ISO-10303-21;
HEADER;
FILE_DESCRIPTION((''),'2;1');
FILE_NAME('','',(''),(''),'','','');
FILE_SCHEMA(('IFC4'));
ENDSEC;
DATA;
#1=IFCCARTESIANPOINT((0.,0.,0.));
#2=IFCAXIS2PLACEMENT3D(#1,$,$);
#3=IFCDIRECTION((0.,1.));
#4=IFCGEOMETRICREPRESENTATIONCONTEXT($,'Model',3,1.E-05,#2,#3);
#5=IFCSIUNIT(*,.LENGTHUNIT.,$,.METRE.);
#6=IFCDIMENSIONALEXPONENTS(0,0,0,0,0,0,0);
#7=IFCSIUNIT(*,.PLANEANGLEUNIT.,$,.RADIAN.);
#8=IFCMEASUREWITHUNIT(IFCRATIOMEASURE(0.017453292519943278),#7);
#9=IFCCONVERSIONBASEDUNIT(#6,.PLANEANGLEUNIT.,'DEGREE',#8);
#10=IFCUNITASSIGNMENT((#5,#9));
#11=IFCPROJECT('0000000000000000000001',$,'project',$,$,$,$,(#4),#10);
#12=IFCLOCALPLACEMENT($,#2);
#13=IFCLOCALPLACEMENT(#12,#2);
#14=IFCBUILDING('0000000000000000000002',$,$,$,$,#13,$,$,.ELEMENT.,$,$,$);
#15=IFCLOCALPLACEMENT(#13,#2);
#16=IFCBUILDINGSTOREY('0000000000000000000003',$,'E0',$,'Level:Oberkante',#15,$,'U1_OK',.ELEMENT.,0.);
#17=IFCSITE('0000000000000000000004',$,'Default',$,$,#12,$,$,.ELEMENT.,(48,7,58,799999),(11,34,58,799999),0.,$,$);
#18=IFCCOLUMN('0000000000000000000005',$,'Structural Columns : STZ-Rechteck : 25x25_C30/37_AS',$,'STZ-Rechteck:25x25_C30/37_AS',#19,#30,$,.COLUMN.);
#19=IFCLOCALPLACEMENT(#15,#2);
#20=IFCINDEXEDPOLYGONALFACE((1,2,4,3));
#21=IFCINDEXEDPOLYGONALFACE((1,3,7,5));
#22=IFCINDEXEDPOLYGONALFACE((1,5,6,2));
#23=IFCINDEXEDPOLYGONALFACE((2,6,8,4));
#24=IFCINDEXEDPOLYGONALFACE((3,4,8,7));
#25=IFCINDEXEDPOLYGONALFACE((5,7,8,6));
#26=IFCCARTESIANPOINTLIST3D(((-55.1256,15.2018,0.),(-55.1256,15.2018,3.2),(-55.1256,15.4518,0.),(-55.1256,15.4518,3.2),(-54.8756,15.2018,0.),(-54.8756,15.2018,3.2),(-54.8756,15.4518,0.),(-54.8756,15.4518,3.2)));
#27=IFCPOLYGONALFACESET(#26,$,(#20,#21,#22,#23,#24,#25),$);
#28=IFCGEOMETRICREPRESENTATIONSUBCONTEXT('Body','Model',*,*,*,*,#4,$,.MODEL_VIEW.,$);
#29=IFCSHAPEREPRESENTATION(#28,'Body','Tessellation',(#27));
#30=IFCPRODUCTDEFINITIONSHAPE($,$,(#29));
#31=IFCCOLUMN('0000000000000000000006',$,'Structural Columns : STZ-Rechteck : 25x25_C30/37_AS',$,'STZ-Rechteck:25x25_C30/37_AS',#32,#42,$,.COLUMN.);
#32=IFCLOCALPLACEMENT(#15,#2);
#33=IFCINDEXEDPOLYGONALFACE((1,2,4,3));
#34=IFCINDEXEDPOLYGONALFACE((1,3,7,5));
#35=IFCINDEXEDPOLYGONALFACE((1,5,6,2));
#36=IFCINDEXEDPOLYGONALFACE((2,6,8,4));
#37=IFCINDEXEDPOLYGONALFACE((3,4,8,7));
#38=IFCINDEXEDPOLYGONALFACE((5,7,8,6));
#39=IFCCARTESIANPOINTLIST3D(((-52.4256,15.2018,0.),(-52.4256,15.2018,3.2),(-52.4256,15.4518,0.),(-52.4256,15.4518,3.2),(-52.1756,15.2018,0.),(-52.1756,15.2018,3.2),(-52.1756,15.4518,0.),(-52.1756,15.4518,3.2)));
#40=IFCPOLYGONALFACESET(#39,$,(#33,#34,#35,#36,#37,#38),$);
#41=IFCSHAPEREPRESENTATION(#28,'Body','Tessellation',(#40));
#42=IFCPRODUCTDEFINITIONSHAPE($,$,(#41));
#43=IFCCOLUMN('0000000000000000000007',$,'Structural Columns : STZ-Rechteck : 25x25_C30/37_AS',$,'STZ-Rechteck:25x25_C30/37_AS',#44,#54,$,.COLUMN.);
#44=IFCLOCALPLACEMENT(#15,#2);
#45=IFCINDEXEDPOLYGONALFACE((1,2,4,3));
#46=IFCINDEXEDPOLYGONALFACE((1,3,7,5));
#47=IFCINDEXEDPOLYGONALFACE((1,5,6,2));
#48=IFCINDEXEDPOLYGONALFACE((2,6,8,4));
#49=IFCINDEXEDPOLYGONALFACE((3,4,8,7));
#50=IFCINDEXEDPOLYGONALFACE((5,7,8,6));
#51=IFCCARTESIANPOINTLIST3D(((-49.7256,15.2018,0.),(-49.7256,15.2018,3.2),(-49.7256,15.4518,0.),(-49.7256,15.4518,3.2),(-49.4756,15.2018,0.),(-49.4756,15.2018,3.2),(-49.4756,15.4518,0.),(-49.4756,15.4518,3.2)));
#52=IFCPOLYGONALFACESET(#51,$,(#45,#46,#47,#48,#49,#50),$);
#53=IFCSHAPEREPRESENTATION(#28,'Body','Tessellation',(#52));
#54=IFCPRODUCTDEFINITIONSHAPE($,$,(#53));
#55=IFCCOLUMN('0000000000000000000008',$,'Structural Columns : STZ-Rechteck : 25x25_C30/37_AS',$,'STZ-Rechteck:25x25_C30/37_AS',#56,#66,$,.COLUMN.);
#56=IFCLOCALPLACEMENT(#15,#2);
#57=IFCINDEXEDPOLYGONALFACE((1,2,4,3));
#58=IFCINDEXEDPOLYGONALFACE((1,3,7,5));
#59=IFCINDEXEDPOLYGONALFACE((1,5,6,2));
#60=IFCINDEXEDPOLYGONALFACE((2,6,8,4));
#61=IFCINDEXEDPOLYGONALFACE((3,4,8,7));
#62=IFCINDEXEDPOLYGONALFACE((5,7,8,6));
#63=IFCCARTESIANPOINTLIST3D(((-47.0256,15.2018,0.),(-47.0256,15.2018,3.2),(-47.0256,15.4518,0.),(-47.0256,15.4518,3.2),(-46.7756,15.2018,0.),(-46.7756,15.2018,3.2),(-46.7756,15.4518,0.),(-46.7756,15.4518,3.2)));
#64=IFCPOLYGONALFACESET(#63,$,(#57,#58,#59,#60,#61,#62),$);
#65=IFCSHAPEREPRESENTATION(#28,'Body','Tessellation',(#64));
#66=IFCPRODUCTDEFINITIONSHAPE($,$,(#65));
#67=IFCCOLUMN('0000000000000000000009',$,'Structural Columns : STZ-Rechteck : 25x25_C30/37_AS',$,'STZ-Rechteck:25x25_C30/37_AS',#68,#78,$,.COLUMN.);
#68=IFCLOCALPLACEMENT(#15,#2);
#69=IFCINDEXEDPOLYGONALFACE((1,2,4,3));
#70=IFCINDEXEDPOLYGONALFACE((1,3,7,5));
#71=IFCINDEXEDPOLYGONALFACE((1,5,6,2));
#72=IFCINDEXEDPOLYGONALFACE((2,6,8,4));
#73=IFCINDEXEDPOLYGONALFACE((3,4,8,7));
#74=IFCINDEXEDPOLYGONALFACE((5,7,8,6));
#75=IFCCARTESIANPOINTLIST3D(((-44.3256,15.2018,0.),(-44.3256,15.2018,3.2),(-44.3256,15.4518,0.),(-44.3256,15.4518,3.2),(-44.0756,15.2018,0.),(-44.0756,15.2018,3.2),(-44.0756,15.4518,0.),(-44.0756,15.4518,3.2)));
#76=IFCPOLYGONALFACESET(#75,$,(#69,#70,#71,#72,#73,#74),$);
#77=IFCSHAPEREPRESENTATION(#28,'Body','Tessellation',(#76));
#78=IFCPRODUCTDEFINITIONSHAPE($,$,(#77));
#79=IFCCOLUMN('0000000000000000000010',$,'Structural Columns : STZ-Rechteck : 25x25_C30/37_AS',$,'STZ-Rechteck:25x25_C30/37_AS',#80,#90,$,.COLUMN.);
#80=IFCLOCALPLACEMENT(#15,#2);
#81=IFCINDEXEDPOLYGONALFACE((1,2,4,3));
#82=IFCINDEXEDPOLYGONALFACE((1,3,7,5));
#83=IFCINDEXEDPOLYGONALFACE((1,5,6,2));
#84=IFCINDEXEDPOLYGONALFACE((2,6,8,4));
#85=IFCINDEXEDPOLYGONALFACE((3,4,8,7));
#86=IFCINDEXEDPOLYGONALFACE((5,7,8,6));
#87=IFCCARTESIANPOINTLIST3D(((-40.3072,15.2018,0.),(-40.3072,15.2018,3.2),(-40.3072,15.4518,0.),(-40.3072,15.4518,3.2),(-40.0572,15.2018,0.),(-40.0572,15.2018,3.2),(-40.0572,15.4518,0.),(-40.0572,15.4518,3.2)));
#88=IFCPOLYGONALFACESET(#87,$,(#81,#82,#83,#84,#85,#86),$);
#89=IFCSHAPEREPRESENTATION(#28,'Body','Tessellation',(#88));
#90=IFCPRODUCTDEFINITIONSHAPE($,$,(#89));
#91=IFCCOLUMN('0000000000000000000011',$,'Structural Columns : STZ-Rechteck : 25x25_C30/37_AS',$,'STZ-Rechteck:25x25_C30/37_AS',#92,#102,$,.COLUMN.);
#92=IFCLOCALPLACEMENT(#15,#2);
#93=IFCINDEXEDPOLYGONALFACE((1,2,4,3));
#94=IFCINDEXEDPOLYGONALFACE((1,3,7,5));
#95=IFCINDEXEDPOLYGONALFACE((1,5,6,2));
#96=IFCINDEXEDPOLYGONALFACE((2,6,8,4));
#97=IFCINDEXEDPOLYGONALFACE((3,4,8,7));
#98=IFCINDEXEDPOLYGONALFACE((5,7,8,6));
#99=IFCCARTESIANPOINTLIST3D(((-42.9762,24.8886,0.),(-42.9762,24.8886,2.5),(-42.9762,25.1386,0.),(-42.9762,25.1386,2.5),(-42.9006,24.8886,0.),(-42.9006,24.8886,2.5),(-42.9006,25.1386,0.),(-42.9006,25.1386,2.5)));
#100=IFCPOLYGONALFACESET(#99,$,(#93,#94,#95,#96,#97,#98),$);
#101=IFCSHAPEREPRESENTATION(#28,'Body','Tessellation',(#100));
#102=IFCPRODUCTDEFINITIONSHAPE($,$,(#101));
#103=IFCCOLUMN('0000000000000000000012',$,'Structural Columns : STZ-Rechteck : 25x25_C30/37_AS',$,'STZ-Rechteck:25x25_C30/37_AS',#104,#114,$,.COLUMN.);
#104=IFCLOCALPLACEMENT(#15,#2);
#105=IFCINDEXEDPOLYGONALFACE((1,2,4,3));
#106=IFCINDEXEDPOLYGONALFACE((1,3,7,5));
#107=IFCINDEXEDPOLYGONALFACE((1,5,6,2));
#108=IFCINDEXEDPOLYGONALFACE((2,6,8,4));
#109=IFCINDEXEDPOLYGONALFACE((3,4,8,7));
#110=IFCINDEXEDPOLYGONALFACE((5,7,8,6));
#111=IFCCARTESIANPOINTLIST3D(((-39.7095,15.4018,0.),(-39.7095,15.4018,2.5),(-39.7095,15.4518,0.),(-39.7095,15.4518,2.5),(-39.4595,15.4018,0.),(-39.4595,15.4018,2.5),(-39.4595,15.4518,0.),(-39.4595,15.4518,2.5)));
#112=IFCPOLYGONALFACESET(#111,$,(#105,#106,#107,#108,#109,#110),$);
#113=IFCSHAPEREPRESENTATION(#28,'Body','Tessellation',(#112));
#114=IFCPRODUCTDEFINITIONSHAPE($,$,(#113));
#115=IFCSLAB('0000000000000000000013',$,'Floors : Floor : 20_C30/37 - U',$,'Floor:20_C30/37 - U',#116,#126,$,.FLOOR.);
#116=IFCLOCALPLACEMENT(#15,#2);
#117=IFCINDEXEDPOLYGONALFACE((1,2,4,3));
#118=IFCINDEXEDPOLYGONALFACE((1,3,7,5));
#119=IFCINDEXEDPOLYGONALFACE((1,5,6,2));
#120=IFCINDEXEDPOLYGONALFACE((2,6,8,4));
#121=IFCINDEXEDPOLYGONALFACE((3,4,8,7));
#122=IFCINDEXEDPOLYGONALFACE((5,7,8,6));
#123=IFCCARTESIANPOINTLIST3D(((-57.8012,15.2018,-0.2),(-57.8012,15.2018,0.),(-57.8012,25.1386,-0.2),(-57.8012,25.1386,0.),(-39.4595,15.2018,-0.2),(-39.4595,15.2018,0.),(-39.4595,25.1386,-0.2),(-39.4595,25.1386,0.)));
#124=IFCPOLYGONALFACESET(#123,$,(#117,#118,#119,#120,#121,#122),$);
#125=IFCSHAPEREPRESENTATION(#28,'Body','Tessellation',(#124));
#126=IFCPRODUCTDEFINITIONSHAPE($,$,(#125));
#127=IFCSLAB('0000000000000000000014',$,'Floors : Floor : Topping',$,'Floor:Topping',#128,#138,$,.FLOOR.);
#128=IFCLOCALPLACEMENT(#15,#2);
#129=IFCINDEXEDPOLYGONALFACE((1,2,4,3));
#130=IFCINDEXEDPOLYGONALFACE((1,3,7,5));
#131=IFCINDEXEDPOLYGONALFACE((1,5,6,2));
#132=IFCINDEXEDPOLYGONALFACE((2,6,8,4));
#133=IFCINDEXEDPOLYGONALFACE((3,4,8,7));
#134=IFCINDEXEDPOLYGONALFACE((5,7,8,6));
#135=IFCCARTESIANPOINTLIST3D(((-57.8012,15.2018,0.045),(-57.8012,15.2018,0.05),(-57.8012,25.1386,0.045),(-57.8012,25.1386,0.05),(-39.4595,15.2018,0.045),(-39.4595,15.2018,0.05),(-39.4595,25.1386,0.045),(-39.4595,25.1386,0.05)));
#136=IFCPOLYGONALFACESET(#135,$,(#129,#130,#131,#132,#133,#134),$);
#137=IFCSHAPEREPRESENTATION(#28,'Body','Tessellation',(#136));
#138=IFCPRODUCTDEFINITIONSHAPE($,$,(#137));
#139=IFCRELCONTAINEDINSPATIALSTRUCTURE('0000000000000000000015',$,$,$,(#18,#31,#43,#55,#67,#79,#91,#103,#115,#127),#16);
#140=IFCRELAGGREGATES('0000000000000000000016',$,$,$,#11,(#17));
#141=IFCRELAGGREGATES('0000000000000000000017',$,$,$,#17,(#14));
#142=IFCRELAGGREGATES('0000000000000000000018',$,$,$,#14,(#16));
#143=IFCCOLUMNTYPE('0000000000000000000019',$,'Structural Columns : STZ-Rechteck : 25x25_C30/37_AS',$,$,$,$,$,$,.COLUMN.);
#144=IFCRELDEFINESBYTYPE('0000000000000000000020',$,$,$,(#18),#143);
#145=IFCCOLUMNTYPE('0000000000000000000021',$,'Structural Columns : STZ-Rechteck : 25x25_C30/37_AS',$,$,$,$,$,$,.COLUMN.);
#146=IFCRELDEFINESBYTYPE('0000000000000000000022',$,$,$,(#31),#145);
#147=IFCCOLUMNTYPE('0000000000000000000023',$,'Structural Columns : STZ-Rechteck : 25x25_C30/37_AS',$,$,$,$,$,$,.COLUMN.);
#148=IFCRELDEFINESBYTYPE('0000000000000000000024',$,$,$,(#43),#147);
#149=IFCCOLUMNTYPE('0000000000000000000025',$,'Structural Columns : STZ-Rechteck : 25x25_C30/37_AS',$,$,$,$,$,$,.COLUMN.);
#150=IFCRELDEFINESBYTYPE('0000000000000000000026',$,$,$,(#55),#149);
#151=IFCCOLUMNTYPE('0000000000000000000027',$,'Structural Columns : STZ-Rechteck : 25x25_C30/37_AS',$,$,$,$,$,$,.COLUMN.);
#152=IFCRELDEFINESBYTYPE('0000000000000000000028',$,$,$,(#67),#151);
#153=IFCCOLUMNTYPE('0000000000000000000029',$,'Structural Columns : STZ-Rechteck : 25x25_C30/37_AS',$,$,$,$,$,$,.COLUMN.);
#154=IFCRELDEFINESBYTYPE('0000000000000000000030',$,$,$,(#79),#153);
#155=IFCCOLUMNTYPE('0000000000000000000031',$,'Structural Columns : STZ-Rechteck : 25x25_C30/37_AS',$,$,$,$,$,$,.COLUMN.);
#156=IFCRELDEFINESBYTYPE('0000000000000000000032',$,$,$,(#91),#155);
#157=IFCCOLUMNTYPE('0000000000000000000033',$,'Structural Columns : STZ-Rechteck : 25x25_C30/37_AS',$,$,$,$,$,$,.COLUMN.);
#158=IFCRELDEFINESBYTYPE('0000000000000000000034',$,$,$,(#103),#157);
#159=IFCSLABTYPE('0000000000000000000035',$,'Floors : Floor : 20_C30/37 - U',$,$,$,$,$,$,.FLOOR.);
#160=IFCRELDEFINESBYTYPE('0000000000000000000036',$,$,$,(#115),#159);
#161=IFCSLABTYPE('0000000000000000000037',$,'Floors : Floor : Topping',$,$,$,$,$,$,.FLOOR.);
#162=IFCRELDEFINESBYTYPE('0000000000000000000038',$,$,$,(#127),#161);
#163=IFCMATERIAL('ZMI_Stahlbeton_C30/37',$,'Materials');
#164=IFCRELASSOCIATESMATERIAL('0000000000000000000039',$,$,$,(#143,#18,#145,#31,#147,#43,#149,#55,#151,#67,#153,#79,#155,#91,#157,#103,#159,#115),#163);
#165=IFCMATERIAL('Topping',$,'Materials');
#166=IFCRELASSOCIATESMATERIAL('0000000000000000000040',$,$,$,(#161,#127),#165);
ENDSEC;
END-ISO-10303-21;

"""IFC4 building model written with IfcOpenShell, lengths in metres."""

from ifc_helpers import new_model, entity, si_unit, converted_unit, direction, frame, origin, place, context, subcontext, project, spatial, indexed_curve, outline, extrude, source, transform, mapped, material, type_object, type_shapes, element, save


model = new_model("IFC4")

# Units and contexts
model_context = context("Model", 3, precision=1e-05, world=origin(), true_north=direction((0.0, 1.0)))
body_context = subcontext(model_context, "Body", "Model", "MODEL_VIEW")
ifc_project = project(units=[si_unit("LENGTHUNIT", "METRE"), converted_unit("PLANEANGLEUNIT", "DEGREE", entity("IfcRatioMeasure", 0.017453292519943278), si_unit("PLANEANGLEUNIT", "RADIAN"), dimensions=[0, 0, 0, 0, 0, 0, 0])], contexts=[model_context])

# Site, building, storey
site_placement = place(None, origin())
site = spatial("IfcSite", under=ifc_project, at=site_placement, Name="Default", CompositionType="ELEMENT", RefLatitude=(48, 7, 58, 799999), RefLongitude=(11, 34, 58, 799999), RefElevation=0.0)
building_placement = place(site_placement, origin())
building = spatial("IfcBuilding", under=site, at=building_placement, CompositionType="ELEMENT")
storey_placement = place(building_placement, origin())
storey = spatial("IfcBuildingStorey", under=building, at=storey_placement, Name="E0", ObjectType="Level:Oberkante", LongName="U1_OK", CompositionType="ELEMENT", Elevation=0.0)

# Columns
ifc_material_1 = material(Name="ZMI_Stahlbeton_C30/37", Category="Materials")
column_type_1 = type_object("IfcColumnType", Name="Structural Columns : STZ-Rechteck : 25x25_C30/37_AS", PredefinedType="COLUMN", material=ifc_material_1)
shared_shape_1 = source(origin(), body_context, "Body", "SweptSolid", [
    extrude(outline(indexed_curve([(-0.125, -0.125), (0.125, -0.125), (0.125, 0.125), (-0.125, 0.125), (-0.125, -0.125)], self_intersect=False)), frame((-55.0006, 15.3268, 0.0), z_axis=(0.0, 0.0, 1.0), x_axis=(0.0, -1.0, 0.0)), (0.0, 0.0, 1.0), 3.2),
])
type_shapes(column_type_1, [shared_shape_1])
column_1_placement = place(storey_placement, origin())
element("IfcColumn", 1, at=column_1_placement, inside=storey, type_object=column_type_1, material=ifc_material_1, Name="Structural Columns : STZ-Rechteck : 25x25_C30/37_AS", ObjectType="STZ-Rechteck:25x25_C30/37_AS", PredefinedType="COLUMN", context=body_context, shape_type="MappedRepresentation", body=[
    mapped(shared_shape_1, transform((0.0, 0.0, 0.0), scale=1.0)),
])
column_type_2 = type_object("IfcColumnType", Name="Structural Columns : STZ-Rechteck : 25x25_C30/37_AS", PredefinedType="COLUMN", material=ifc_material_1)
shared_shape_2 = source(origin(), body_context, "Body", "SweptSolid", [
    extrude(outline(indexed_curve([(-0.125, -0.125), (0.125, -0.125), (0.125, 0.125), (-0.125, 0.125), (-0.125, -0.125)], self_intersect=False)), frame((-52.3006, 15.3268, 0.0), z_axis=(0.0, 0.0, 1.0), x_axis=(0.0, -1.0, 0.0)), (0.0, 0.0, 1.0), 3.2),
])
type_shapes(column_type_2, [shared_shape_2])
column_2_placement = place(storey_placement, origin())
element("IfcColumn", 2, at=column_2_placement, inside=storey, type_object=column_type_2, material=ifc_material_1, Name="Structural Columns : STZ-Rechteck : 25x25_C30/37_AS", ObjectType="STZ-Rechteck:25x25_C30/37_AS", PredefinedType="COLUMN", context=body_context, shape_type="MappedRepresentation", body=[
    mapped(shared_shape_2, transform((0.0, 0.0, 0.0), scale=1.0)),
])
column_type_3 = type_object("IfcColumnType", Name="Structural Columns : STZ-Rechteck : 25x25_C30/37_AS", PredefinedType="COLUMN", material=ifc_material_1)
shared_shape_3 = source(origin(), body_context, "Body", "SweptSolid", [
    extrude(outline(indexed_curve([(-0.125, -0.125), (0.125, -0.125), (0.125, 0.125), (-0.125, 0.125), (-0.125, -0.125)], self_intersect=False)), frame((-49.6006, 15.3268, 0.0), z_axis=(0.0, 0.0, 1.0), x_axis=(0.0, -1.0, 0.0)), (0.0, 0.0, 1.0), 3.2),
])
type_shapes(column_type_3, [shared_shape_3])
column_3_placement = place(storey_placement, origin())
element("IfcColumn", 3, at=column_3_placement, inside=storey, type_object=column_type_3, material=ifc_material_1, Name="Structural Columns : STZ-Rechteck : 25x25_C30/37_AS", ObjectType="STZ-Rechteck:25x25_C30/37_AS", PredefinedType="COLUMN", context=body_context, shape_type="MappedRepresentation", body=[
    mapped(shared_shape_3, transform((0.0, 0.0, 0.0), scale=1.0)),
])
column_type_4 = type_object("IfcColumnType", Name="Structural Columns : STZ-Rechteck : 25x25_C30/37_AS", PredefinedType="COLUMN", material=ifc_material_1)
shared_shape_4 = source(origin(), body_context, "Body", "SweptSolid", [
    extrude(outline(indexed_curve([(-0.125, -0.125), (0.125, -0.125), (0.125, 0.125), (-0.125, 0.125), (-0.125, -0.125)], self_intersect=False)), frame((-46.9006, 15.3268, 0.0), z_axis=(0.0, 0.0, 1.0), x_axis=(0.0, -1.0, 0.0)), (0.0, 0.0, 1.0), 3.2),
])
type_shapes(column_type_4, [shared_shape_4])
column_4_placement = place(storey_placement, origin())
element("IfcColumn", 4, at=column_4_placement, inside=storey, type_object=column_type_4, material=ifc_material_1, Name="Structural Columns : STZ-Rechteck : 25x25_C30/37_AS", ObjectType="STZ-Rechteck:25x25_C30/37_AS", PredefinedType="COLUMN", context=body_context, shape_type="MappedRepresentation", body=[
    mapped(shared_shape_4, transform((0.0, 0.0, 0.0), scale=1.0)),
])
column_type_5 = type_object("IfcColumnType", Name="Structural Columns : STZ-Rechteck : 25x25_C30/37_AS", PredefinedType="COLUMN", material=ifc_material_1)
shared_shape_5 = source(origin(), body_context, "Body", "SweptSolid", [
    extrude(outline(indexed_curve([(-0.125, -0.125), (0.125, -0.125), (0.125, 0.125), (-0.125, 0.125), (-0.125, -0.125)], self_intersect=False)), frame((-44.2006, 15.3268, 0.0), z_axis=(0.0, 0.0, 1.0), x_axis=(0.0, -1.0, 0.0)), (0.0, 0.0, 1.0), 3.2),
])
type_shapes(column_type_5, [shared_shape_5])
column_5_placement = place(storey_placement, origin())
element("IfcColumn", 5, at=column_5_placement, inside=storey, type_object=column_type_5, material=ifc_material_1, Name="Structural Columns : STZ-Rechteck : 25x25_C30/37_AS", ObjectType="STZ-Rechteck:25x25_C30/37_AS", PredefinedType="COLUMN", context=body_context, shape_type="MappedRepresentation", body=[
    mapped(shared_shape_5, transform((0.0, 0.0, 0.0), scale=1.0)),
])
column_type_6 = type_object("IfcColumnType", Name="Structural Columns : STZ-Rechteck : 25x25_C30/37_AS", PredefinedType="COLUMN", material=ifc_material_1)
shared_shape_6 = source(origin(), body_context, "Body", "SweptSolid", [
    extrude(outline(indexed_curve([(-0.125, -0.125), (0.125, -0.125), (0.125, 0.125), (-0.125, 0.125), (-0.125, -0.125)], self_intersect=False)), frame((-40.1822, 15.3268, 0.0), z_axis=(0.0, 0.0, 1.0), x_axis=(0.0, -1.0, 0.0)), (0.0, 0.0, 1.0), 3.2),
])
type_shapes(column_type_6, [shared_shape_6])
column_6_placement = place(storey_placement, origin())
element("IfcColumn", 6, at=column_6_placement, inside=storey, type_object=column_type_6, material=ifc_material_1, Name="Structural Columns : STZ-Rechteck : 25x25_C30/37_AS", ObjectType="STZ-Rechteck:25x25_C30/37_AS", PredefinedType="COLUMN", context=body_context, shape_type="MappedRepresentation", body=[
    mapped(shared_shape_6, transform((0.0, 0.0, 0.0), scale=1.0)),
])
column_type_7 = type_object("IfcColumnType", Name="Structural Columns : STZ-Rechteck : 25x25_C30/37_AS", PredefinedType="COLUMN", material=ifc_material_1)
shared_shape_7 = source(origin(), body_context, "Body", "SweptSolid", [
    extrude(outline(indexed_curve([(-0.125, -0.0378), (0.125, -0.0378), (0.125, 0.0378), (-0.125, 0.0378), (-0.125, -0.0378)], self_intersect=False)), frame((-42.9384, 25.0136, 0.0), z_axis=(0.0, 0.0, 1.0), x_axis=(0.0, -1.0, 0.0)), (0.0, 0.0, 1.0), 2.5),
])
type_shapes(column_type_7, [shared_shape_7])
column_7_placement = place(storey_placement, origin())
element("IfcColumn", 7, at=column_7_placement, inside=storey, type_object=column_type_7, material=ifc_material_1, Name="Structural Columns : STZ-Rechteck : 25x25_C30/37_AS", ObjectType="STZ-Rechteck:25x25_C30/37_AS", PredefinedType="COLUMN", context=body_context, shape_type="MappedRepresentation", body=[
    mapped(shared_shape_7, transform((0.0, 0.0, 0.0), scale=1.0)),
])
column_type_8 = type_object("IfcColumnType", Name="Structural Columns : STZ-Rechteck : 25x25_C30/37_AS", PredefinedType="COLUMN", material=ifc_material_1)
shared_shape_8 = source(origin(), body_context, "Body", "SweptSolid", [
    extrude(outline(indexed_curve([(-0.025, -0.125), (0.025, -0.125), (0.025, 0.125), (-0.025, 0.125), (-0.025, -0.125)], self_intersect=False)), frame((-39.5845, 15.4268, 0.0), z_axis=(0.0, 0.0, 1.0), x_axis=(0.0, -1.0, 0.0)), (0.0, 0.0, 1.0), 2.5),
])
type_shapes(column_type_8, [shared_shape_8])
column_8_placement = place(storey_placement, origin())
element("IfcColumn", 8, at=column_8_placement, inside=storey, type_object=column_type_8, material=ifc_material_1, Name="Structural Columns : STZ-Rechteck : 25x25_C30/37_AS", ObjectType="STZ-Rechteck:25x25_C30/37_AS", PredefinedType="COLUMN", context=body_context, shape_type="MappedRepresentation", body=[
    mapped(shared_shape_8, transform((0.0, 0.0, 0.0), scale=1.0)),
])

# Slabs
slab_type_1 = type_object("IfcSlabType", Name="Floors : Floor : 20_C30/37 - U", PredefinedType="FLOOR", material=ifc_material_1)
slab_1_placement = place(storey_placement, origin())
element("IfcSlab", 9, at=slab_1_placement, inside=storey, type_object=slab_type_1, material=ifc_material_1, Name="Floors : Floor : 20_C30/37 - U", ObjectType="Floor:20_C30/37 - U", PredefinedType="FLOOR", context=body_context, shape_type="SweptSolid", body=[
    extrude(outline(indexed_curve([(-4.9684, -9.1708), (4.9684, -9.1708), (4.9684, 9.1708), (-4.9684, 9.1708), (-4.9684, -9.1708)], self_intersect=False)), frame((-48.6303, 20.1702, 0.0), z_axis=(0.0, 0.0, -1.0), x_axis=(0.0, 1.0, 0.0)), (0.0, 0.0, 1.0), 0.2),
])
ifc_material_2 = material(Name="Topping", Category="Materials")
slab_type_2 = type_object("IfcSlabType", Name="Floors : Floor : Topping", PredefinedType="FLOOR", material=ifc_material_2)
slab_2_placement = place(storey_placement, origin())
element("IfcSlab", 10, at=slab_2_placement, inside=storey, type_object=slab_type_2, material=ifc_material_2, Name="Floors : Floor : Topping", ObjectType="Floor:Topping", PredefinedType="FLOOR", context=body_context, shape_type="SweptSolid", body=[
    extrude(outline(indexed_curve([(-4.9684, -9.1708), (4.9684, -9.1708), (4.9684, 9.1708), (-4.9684, 9.1708), (-4.9684, -9.1708)], self_intersect=False)), frame((-48.6303, 20.1702, 0.05), z_axis=(0.0, 0.0, -1.0), x_axis=(0.0, 1.0, 0.0)), (0.0, 0.0, 1.0), 0.005),
])

save(model, "model.ifc")
